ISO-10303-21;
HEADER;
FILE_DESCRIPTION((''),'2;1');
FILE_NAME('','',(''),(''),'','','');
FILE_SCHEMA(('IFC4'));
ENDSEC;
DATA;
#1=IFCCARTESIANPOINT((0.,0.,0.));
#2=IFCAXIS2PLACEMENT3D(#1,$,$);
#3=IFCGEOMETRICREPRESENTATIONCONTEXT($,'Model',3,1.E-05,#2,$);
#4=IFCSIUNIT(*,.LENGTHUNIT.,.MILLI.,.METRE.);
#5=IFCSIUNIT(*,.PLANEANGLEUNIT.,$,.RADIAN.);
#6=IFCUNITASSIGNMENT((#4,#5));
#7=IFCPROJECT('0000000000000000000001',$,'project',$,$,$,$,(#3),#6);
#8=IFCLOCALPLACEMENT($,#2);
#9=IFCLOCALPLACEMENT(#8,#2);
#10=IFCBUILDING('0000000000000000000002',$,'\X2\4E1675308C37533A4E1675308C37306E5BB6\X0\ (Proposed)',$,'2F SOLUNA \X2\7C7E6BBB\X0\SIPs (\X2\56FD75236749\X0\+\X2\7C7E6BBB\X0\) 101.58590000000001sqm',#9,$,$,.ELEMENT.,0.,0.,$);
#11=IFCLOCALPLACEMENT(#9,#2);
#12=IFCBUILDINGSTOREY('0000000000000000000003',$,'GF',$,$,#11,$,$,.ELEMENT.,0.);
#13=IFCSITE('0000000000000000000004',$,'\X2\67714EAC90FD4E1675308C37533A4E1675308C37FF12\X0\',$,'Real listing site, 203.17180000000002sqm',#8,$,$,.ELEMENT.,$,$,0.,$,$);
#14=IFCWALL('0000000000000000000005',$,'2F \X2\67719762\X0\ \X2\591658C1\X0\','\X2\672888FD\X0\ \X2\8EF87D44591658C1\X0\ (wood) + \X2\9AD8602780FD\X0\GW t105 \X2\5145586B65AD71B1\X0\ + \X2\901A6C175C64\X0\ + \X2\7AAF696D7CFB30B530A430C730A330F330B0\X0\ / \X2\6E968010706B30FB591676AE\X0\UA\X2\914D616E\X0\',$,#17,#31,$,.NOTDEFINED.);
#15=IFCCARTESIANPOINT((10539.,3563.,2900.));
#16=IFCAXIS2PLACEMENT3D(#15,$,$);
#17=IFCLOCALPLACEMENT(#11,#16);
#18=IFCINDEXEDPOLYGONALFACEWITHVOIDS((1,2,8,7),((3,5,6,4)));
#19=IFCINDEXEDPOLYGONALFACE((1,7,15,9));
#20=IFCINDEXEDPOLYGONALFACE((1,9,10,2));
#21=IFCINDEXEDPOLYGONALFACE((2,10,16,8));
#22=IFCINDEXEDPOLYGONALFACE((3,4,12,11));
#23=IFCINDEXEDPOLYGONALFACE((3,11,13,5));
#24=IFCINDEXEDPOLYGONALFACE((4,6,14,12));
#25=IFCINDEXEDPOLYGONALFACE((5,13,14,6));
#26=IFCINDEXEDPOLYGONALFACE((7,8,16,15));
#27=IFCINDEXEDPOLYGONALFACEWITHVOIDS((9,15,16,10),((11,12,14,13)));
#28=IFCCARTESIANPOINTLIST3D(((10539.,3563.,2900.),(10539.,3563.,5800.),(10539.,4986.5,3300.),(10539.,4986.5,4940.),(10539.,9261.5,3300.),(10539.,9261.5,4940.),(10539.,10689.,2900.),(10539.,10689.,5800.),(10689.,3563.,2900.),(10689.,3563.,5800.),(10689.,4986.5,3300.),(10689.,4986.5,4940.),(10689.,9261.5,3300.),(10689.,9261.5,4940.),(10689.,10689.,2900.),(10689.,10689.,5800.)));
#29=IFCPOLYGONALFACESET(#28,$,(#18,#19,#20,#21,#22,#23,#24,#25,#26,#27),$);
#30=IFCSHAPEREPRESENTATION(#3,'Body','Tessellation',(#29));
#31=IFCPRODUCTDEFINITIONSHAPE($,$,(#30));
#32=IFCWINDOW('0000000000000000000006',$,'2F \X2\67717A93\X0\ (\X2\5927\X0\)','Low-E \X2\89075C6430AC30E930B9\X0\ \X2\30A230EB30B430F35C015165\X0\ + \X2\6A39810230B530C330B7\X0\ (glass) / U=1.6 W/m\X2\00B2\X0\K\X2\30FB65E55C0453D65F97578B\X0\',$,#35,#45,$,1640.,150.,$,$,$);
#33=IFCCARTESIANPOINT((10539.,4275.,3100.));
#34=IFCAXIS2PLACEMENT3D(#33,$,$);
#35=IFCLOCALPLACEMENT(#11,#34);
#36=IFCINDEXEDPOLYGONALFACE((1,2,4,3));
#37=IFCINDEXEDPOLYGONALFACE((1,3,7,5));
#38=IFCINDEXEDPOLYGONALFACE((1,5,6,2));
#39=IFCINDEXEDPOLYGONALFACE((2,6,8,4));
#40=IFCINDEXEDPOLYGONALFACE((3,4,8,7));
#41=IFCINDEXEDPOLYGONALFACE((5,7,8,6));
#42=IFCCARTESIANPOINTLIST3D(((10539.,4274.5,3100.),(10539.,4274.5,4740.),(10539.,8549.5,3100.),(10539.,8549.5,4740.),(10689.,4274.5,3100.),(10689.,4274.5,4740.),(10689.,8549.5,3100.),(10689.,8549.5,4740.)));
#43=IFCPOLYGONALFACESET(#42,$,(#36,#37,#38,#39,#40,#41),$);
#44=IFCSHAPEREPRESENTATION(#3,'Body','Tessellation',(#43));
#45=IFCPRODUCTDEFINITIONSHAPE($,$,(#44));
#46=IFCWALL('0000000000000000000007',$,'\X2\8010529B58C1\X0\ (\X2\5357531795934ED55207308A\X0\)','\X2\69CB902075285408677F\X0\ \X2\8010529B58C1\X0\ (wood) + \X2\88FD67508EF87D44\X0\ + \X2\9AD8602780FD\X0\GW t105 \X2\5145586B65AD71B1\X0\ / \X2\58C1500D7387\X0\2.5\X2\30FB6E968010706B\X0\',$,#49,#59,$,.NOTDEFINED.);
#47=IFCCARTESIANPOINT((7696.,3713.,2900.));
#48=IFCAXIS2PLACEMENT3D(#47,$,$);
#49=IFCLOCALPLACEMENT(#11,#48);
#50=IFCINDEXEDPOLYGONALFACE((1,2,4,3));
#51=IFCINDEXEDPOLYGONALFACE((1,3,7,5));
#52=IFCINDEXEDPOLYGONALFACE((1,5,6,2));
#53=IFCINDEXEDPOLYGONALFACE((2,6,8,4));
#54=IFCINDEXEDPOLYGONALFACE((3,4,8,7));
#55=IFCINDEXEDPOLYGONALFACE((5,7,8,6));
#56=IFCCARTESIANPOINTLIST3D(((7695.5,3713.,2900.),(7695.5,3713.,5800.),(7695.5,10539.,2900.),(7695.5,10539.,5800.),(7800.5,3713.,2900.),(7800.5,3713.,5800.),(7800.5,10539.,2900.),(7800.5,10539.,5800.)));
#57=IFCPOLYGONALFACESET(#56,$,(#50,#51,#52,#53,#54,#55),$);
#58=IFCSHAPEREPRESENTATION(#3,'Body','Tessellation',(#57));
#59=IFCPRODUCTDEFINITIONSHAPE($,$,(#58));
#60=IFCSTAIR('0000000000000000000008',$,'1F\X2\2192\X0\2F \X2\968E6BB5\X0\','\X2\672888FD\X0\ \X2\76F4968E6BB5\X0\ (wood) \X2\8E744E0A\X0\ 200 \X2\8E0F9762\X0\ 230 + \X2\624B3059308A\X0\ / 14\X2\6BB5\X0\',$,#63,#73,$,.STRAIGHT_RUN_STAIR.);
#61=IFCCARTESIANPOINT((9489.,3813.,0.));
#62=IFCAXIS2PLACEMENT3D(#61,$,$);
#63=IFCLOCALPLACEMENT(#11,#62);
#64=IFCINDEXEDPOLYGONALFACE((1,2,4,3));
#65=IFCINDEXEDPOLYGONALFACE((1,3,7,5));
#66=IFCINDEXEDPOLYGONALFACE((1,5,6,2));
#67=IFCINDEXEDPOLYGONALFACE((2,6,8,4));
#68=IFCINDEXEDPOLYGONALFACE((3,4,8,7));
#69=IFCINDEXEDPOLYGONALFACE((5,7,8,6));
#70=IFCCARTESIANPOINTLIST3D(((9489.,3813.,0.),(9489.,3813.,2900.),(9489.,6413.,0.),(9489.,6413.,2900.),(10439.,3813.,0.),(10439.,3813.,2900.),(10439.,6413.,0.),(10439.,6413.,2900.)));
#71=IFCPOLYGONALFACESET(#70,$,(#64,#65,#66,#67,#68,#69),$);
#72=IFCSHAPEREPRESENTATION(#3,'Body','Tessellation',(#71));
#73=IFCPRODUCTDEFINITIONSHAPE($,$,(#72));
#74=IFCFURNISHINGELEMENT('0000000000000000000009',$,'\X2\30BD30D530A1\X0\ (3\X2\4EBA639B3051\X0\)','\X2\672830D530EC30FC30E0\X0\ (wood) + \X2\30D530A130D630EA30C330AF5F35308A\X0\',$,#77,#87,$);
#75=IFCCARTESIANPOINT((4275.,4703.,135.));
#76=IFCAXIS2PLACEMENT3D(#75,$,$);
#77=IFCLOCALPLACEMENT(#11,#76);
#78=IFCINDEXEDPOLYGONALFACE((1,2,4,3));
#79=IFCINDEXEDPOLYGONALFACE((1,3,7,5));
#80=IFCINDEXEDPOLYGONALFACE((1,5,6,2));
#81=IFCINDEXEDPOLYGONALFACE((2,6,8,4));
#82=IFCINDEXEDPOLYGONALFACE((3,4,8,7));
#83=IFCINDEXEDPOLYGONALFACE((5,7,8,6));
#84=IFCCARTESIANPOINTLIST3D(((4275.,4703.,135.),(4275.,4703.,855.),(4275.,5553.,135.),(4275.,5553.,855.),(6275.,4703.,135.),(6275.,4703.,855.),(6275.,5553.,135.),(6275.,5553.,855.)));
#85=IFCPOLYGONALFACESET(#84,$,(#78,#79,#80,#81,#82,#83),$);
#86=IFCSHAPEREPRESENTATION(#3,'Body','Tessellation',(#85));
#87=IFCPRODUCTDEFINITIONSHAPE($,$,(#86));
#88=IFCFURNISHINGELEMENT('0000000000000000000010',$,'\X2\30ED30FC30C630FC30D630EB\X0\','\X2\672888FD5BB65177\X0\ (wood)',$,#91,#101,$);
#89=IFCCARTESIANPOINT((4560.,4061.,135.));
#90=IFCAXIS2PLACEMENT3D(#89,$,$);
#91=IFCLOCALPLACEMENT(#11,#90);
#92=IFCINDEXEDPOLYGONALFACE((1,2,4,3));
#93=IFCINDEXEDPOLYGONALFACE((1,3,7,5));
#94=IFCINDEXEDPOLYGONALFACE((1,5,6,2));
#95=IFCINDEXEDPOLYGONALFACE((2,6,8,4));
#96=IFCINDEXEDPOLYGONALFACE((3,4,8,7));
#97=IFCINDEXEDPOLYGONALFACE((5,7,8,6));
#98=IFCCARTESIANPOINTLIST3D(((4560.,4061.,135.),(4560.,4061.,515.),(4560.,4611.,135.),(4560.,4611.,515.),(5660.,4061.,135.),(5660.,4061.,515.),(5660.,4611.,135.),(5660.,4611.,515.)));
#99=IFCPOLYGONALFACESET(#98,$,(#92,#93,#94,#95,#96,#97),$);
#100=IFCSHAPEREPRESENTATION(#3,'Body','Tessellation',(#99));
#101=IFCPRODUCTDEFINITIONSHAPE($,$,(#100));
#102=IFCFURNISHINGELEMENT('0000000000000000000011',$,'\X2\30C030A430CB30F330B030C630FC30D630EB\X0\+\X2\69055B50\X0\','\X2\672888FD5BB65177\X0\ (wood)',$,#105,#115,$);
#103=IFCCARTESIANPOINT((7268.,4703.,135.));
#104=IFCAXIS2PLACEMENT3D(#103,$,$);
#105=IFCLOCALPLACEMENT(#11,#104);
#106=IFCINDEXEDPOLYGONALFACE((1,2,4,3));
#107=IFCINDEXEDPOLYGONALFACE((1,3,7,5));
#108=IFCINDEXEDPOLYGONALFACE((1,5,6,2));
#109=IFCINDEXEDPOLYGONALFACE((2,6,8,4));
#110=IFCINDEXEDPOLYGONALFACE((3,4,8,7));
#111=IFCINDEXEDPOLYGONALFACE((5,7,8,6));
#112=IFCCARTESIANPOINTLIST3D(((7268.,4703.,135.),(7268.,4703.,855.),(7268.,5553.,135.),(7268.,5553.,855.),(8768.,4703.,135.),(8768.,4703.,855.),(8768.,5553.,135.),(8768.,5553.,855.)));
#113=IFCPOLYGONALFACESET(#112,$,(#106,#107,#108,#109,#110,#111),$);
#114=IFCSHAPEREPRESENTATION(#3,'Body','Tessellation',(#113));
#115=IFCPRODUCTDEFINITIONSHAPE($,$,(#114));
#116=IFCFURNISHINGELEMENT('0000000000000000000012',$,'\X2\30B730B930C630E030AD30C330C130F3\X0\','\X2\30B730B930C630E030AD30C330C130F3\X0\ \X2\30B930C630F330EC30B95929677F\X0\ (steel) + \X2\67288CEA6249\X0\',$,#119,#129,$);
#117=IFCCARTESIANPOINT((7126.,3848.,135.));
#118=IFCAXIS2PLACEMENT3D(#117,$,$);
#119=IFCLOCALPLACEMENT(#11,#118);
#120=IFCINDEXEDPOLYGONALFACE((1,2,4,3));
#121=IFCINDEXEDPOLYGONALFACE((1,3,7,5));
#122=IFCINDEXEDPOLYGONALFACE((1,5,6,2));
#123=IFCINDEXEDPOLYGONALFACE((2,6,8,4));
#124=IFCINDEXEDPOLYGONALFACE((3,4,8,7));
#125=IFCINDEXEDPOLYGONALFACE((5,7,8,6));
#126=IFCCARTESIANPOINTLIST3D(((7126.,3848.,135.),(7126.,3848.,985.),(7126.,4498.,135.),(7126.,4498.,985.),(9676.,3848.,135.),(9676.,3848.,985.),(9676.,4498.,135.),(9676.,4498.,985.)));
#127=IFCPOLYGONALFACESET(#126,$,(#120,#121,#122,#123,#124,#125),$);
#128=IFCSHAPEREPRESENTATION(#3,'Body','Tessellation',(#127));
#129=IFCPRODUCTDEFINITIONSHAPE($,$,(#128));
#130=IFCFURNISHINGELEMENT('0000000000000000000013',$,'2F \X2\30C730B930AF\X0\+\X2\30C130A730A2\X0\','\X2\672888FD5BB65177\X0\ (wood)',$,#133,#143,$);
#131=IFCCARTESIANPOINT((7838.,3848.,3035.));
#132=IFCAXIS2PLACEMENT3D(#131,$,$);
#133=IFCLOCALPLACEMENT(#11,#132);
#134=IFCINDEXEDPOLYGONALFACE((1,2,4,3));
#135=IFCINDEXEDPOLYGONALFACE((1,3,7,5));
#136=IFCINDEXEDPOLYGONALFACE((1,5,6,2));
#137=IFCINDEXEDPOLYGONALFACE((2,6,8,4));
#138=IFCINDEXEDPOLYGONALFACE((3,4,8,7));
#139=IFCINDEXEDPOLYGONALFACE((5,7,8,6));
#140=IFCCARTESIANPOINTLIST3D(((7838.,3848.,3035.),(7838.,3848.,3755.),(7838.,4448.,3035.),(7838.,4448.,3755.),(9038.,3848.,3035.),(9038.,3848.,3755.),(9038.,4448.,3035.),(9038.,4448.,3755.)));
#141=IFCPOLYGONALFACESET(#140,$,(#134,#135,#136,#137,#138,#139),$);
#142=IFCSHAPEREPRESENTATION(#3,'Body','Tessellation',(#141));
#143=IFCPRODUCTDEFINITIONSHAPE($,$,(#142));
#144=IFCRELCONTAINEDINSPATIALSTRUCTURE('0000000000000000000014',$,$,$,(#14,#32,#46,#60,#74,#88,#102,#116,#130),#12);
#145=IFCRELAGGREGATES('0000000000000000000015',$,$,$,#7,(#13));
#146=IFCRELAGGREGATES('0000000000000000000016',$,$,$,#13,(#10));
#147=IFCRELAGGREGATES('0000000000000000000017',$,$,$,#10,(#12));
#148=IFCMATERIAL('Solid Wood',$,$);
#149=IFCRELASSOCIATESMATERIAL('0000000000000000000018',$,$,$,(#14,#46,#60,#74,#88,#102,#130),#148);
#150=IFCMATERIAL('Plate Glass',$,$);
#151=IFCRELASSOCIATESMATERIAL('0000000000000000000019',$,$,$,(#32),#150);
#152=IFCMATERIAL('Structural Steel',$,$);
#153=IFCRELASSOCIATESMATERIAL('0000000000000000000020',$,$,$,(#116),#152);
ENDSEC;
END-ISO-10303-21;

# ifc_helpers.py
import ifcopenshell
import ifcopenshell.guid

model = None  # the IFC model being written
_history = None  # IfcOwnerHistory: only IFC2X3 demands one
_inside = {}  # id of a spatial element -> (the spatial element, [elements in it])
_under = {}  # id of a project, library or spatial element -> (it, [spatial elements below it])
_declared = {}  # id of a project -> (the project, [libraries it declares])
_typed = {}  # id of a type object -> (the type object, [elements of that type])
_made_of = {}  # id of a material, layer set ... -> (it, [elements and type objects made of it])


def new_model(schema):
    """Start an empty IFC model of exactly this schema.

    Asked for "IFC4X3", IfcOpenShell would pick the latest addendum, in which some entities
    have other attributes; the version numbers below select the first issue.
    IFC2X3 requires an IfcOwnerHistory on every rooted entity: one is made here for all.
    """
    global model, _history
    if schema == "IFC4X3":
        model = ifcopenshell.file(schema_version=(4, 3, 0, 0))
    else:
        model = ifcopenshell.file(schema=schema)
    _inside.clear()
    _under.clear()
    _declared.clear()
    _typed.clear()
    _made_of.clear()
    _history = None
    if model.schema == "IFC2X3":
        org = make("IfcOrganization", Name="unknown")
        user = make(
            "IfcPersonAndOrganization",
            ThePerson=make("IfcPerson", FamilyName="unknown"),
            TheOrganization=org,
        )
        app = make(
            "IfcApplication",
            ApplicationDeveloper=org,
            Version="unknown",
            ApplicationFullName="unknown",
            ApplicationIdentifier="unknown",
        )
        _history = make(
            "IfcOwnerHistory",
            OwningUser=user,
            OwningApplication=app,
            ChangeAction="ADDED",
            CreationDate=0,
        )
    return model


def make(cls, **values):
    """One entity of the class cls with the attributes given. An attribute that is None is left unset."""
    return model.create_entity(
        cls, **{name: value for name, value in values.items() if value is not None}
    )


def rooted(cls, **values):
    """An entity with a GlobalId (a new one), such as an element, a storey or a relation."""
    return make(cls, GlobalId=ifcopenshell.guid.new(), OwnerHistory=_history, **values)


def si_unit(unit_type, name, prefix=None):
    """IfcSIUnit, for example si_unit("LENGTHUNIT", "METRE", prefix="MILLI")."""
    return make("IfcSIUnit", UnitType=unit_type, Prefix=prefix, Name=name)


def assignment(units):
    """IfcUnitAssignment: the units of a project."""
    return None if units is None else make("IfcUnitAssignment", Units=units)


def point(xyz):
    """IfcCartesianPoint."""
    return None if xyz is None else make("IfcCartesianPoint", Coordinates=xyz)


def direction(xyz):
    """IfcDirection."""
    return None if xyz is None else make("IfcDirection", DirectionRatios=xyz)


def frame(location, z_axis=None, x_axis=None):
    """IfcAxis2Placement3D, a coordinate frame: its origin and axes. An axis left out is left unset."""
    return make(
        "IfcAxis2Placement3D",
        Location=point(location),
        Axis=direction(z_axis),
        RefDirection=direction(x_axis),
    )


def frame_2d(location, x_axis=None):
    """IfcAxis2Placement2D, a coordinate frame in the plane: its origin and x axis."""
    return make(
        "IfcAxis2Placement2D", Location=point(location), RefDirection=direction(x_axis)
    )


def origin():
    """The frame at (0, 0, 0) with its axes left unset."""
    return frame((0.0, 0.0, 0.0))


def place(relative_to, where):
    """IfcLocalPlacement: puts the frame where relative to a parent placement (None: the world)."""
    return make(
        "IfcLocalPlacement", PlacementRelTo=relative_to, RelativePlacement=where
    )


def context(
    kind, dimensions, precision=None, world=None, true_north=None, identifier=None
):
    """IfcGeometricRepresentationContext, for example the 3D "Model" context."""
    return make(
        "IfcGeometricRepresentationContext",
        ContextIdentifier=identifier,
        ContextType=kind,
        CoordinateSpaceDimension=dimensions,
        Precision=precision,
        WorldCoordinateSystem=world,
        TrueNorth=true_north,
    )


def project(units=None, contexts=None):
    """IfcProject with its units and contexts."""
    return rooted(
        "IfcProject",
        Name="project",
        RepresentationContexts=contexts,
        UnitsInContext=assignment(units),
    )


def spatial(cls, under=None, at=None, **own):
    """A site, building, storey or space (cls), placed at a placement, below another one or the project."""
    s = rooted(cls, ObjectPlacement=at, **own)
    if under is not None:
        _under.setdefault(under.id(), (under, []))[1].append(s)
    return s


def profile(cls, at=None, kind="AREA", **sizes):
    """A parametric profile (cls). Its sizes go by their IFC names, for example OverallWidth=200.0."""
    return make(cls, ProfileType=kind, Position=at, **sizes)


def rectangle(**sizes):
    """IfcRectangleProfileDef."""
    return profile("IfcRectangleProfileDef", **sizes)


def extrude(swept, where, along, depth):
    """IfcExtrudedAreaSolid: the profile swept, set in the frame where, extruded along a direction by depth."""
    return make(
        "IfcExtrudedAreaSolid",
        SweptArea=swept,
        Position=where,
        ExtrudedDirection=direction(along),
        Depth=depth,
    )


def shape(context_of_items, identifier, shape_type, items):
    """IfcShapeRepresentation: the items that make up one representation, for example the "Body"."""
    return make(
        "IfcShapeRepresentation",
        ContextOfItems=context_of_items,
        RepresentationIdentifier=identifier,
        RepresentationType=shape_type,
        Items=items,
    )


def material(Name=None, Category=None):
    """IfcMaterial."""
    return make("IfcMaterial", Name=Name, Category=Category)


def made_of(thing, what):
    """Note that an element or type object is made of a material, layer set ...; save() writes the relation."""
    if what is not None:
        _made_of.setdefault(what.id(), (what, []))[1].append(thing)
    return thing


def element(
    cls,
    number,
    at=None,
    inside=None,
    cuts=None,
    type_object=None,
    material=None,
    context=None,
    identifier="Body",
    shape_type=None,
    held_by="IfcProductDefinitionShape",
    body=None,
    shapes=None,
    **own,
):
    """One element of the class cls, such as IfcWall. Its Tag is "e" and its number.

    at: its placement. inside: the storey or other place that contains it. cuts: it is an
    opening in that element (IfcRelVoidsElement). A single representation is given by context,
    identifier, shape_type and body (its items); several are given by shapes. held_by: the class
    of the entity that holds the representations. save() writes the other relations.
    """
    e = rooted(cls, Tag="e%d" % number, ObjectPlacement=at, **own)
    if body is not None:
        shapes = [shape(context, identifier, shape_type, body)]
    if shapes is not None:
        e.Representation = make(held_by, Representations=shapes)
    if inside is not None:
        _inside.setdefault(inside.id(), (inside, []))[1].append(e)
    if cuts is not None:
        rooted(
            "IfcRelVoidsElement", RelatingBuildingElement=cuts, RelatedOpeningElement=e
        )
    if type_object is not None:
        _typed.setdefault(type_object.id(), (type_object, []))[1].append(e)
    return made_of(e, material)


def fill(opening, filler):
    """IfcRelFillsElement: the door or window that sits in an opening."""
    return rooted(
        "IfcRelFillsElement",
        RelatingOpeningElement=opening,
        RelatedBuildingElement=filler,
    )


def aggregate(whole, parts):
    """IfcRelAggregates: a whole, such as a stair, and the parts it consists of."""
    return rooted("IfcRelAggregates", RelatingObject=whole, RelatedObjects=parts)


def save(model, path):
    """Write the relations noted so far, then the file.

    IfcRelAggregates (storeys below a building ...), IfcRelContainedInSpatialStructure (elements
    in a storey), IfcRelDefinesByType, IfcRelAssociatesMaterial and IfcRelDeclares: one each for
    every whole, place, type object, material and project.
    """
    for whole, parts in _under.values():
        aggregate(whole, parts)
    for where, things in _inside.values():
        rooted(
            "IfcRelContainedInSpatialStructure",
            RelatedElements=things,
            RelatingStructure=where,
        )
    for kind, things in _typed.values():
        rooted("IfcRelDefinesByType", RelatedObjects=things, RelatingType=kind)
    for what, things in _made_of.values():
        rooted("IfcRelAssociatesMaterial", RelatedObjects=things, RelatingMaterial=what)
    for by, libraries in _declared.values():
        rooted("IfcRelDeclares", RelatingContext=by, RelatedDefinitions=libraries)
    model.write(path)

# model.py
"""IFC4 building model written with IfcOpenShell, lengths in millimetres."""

from ifc_helpers import new_model, si_unit, frame, frame_2d, origin, place, context, project, spatial, rectangle, extrude, material, element, fill, save


model = new_model("IFC4")

# Units and contexts
model_context = context("Model", 3, precision=1e-05, world=origin())
ifc_project = project(units=[si_unit("LENGTHUNIT", "METRE", prefix="MILLI"), si_unit("PLANEANGLEUNIT", "RADIAN")], contexts=[model_context])

# Site, building, storey
site_placement = place(None, origin())
site = spatial("IfcSite", under=ifc_project, at=site_placement, Name="東京都世田谷区世田谷２", ObjectType="Real listing site, 203.17180000000002sqm", CompositionType="ELEMENT", RefElevation=0.0)
building_placement = place(site_placement, origin())
building = spatial("IfcBuilding", under=site, at=building_placement, Name="世田谷区世田谷の家 (Proposed)", ObjectType="2F SOLUNA 籾殻SIPs (国産杉+籾殻) 101.58590000000001sqm", CompositionType="ELEMENT", ElevationOfRefHeight=0.0, ElevationOfTerrain=0.0)
storey_placement = place(building_placement, origin())
storey = spatial("IfcBuildingStorey", under=building, at=storey_placement, Name="GF", CompositionType="ELEMENT", Elevation=0.0)

# Shared definitions
ifc_material_1 = material(Name="Solid Wood")
ifc_material_2 = material(Name="Plate Glass")

# Wall, opening, window
wall_1_placement = place(storey_placement, frame((10539.0, 3563.0, 2900.0)))
wall_1 = element("IfcWall", 1, at=wall_1_placement, inside=storey, material=ifc_material_1, Name="2F 東面 外壁", Description="木製 軸組外壁 (wood) + 高性能GW t105 充填断熱 + 通気層 + 窯業系サイディング / 準耐火・外皮UA配慮", PredefinedType="NOTDEFINED", context=model_context, shape_type="SweptSolid", body=[
    extrude(rectangle(XDim=150.0, YDim=7126.0, at=frame_2d((75.0, 3563.0))), frame((10539.0, 3563.0, 2900.0)), (0.0, 0.0, 1.0), 2900.0),
])
opening_1_placement = place(storey_placement, frame((10539.0, 4275.0, 3100.0)))
opening_1 = element("IfcOpeningElement", 2, at=opening_1_placement, cuts=wall_1, PredefinedType="NOTDEFINED", context=model_context, shape_type="SweptSolid", body=[
    extrude(rectangle(XDim=150.0, YDim=4275.0, at=frame_2d((75.0, 2137.0))), frame((10539.0, 4275.0, 3100.0)), (0.0, 0.0, 1.0), 1640.0),
])
window_1_placement = place(storey_placement, frame((10539.0, 4275.0, 3100.0)))
window_1 = element("IfcWindow", 3, at=window_1_placement, inside=storey, material=ifc_material_2, Name="2F 東窓 (大)", Description="Low-E 複層ガラス アルゴン封入 + 樹脂サッシ (glass) / U=1.6 W/m²K・日射取得型", OverallHeight=1640.0, OverallWidth=150.0, context=model_context, shape_type="SweptSolid", body=[
    extrude(rectangle(XDim=150.0, YDim=4275.0, at=frame_2d((75.0, 2137.0))), frame((10539.0, 4275.0, 3100.0)), (0.0, 0.0, 1.0), 1640.0),
])
fill(opening_1, window_1)

# Wall
wall_2_placement = place(storey_placement, frame((7696.0, 3713.0, 2900.0)))
element("IfcWall", 4, at=wall_2_placement, inside=storey, material=ifc_material_1, Name="耐力壁 (南北間仕切り)", Description="構造用合板 耐力壁 (wood) + 製材軸組 + 高性能GW t105 充填断熱 / 壁倍率2.5・準耐火", PredefinedType="NOTDEFINED", context=model_context, shape_type="SweptSolid", body=[
    extrude(rectangle(XDim=105.0, YDim=6826.0, at=frame_2d((52.0, 3413.0))), frame((7696.0, 3713.0, 2900.0)), (0.0, 0.0, 1.0), 2900.0),
])

# Stair
stair_placement = place(storey_placement, frame((9489.0, 3813.0, 0.0)))
element("IfcStair", 5, at=stair_placement, inside=storey, material=ifc_material_1, Name="1F→2F 階段", Description="木製 直階段 (wood) 蹴上 200 踏面 230 + 手すり / 14段", PredefinedType="STRAIGHT_RUN_STAIR", context=model_context, shape_type="SweptSolid", body=[
    extrude(rectangle(XDim=950.0, YDim=2600.0, at=frame_2d((475.0, 1300.0))), frame((9489.0, 3813.0, 0.0)), (0.0, 0.0, 1.0), 2900.0),
])

# Furnishing elements
furnishing_1_placement = place(storey_placement, frame((4275.0, 4703.0, 135.0)))
element("IfcFurnishingElement", 6, at=furnishing_1_placement, inside=storey, material=ifc_material_1, Name="ソファ (3人掛け)", Description="木フレーム (wood) + ファブリック張り", context=model_context, shape_type="SweptSolid", body=[
    extrude(rectangle(XDim=2000.0, YDim=850.0, at=frame_2d((1000.0, 425.0))), frame((4275.0, 4703.0, 135.0)), (0.0, 0.0, 1.0), 720.0),
])
furnishing_2_placement = place(storey_placement, frame((4560.0, 4061.0, 135.0)))
element("IfcFurnishingElement", 7, at=furnishing_2_placement, inside=storey, material=ifc_material_1, Name="ローテーブル", Description="木製家具 (wood)", context=model_context, shape_type="SweptSolid", body=[
    extrude(rectangle(XDim=1100.0, YDim=550.0, at=frame_2d((550.0, 275.0))), frame((4560.0, 4061.0, 135.0)), (0.0, 0.0, 1.0), 380.0),
])
furnishing_3_placement = place(storey_placement, frame((7268.0, 4703.0, 135.0)))
element("IfcFurnishingElement", 8, at=furnishing_3_placement, inside=storey, material=ifc_material_1, Name="ダイニングテーブル+椅子", Description="木製家具 (wood)", context=model_context, shape_type="SweptSolid", body=[
    extrude(rectangle(XDim=1500.0, YDim=850.0, at=frame_2d((750.0, 425.0))), frame((7268.0, 4703.0, 135.0)), (0.0, 0.0, 1.0), 720.0),
])
ifc_material_3 = material(Name="Structural Steel")
furnishing_4_placement = place(storey_placement, frame((7126.0, 3848.0, 135.0)))
element("IfcFurnishingElement", 9, at=furnishing_4_placement, inside=storey, material=ifc_material_3, Name="システムキッチン", Description="システムキッチン ステンレス天板 (steel) + 木質扉", context=model_context, shape_type="SweptSolid", body=[
    extrude(rectangle(XDim=2550.0, YDim=650.0, at=frame_2d((1275.0, 325.0))), frame((7126.0, 3848.0, 135.0)), (0.0, 0.0, 1.0), 850.0),
])
furnishing_5_placement = place(storey_placement, frame((7838.0, 3848.0, 3035.0)))
element("IfcFurnishingElement", 10, at=furnishing_5_placement, inside=storey, material=ifc_material_1, Name="2F デスク+チェア", Description="木製家具 (wood)", context=model_context, shape_type="SweptSolid", body=[
    extrude(rectangle(XDim=1200.0, YDim=600.0, at=frame_2d((600.0, 300.0))), frame((7838.0, 3848.0, 3035.0)), (0.0, 0.0, 1.0), 720.0),
])

save(model, "model.ifc")
